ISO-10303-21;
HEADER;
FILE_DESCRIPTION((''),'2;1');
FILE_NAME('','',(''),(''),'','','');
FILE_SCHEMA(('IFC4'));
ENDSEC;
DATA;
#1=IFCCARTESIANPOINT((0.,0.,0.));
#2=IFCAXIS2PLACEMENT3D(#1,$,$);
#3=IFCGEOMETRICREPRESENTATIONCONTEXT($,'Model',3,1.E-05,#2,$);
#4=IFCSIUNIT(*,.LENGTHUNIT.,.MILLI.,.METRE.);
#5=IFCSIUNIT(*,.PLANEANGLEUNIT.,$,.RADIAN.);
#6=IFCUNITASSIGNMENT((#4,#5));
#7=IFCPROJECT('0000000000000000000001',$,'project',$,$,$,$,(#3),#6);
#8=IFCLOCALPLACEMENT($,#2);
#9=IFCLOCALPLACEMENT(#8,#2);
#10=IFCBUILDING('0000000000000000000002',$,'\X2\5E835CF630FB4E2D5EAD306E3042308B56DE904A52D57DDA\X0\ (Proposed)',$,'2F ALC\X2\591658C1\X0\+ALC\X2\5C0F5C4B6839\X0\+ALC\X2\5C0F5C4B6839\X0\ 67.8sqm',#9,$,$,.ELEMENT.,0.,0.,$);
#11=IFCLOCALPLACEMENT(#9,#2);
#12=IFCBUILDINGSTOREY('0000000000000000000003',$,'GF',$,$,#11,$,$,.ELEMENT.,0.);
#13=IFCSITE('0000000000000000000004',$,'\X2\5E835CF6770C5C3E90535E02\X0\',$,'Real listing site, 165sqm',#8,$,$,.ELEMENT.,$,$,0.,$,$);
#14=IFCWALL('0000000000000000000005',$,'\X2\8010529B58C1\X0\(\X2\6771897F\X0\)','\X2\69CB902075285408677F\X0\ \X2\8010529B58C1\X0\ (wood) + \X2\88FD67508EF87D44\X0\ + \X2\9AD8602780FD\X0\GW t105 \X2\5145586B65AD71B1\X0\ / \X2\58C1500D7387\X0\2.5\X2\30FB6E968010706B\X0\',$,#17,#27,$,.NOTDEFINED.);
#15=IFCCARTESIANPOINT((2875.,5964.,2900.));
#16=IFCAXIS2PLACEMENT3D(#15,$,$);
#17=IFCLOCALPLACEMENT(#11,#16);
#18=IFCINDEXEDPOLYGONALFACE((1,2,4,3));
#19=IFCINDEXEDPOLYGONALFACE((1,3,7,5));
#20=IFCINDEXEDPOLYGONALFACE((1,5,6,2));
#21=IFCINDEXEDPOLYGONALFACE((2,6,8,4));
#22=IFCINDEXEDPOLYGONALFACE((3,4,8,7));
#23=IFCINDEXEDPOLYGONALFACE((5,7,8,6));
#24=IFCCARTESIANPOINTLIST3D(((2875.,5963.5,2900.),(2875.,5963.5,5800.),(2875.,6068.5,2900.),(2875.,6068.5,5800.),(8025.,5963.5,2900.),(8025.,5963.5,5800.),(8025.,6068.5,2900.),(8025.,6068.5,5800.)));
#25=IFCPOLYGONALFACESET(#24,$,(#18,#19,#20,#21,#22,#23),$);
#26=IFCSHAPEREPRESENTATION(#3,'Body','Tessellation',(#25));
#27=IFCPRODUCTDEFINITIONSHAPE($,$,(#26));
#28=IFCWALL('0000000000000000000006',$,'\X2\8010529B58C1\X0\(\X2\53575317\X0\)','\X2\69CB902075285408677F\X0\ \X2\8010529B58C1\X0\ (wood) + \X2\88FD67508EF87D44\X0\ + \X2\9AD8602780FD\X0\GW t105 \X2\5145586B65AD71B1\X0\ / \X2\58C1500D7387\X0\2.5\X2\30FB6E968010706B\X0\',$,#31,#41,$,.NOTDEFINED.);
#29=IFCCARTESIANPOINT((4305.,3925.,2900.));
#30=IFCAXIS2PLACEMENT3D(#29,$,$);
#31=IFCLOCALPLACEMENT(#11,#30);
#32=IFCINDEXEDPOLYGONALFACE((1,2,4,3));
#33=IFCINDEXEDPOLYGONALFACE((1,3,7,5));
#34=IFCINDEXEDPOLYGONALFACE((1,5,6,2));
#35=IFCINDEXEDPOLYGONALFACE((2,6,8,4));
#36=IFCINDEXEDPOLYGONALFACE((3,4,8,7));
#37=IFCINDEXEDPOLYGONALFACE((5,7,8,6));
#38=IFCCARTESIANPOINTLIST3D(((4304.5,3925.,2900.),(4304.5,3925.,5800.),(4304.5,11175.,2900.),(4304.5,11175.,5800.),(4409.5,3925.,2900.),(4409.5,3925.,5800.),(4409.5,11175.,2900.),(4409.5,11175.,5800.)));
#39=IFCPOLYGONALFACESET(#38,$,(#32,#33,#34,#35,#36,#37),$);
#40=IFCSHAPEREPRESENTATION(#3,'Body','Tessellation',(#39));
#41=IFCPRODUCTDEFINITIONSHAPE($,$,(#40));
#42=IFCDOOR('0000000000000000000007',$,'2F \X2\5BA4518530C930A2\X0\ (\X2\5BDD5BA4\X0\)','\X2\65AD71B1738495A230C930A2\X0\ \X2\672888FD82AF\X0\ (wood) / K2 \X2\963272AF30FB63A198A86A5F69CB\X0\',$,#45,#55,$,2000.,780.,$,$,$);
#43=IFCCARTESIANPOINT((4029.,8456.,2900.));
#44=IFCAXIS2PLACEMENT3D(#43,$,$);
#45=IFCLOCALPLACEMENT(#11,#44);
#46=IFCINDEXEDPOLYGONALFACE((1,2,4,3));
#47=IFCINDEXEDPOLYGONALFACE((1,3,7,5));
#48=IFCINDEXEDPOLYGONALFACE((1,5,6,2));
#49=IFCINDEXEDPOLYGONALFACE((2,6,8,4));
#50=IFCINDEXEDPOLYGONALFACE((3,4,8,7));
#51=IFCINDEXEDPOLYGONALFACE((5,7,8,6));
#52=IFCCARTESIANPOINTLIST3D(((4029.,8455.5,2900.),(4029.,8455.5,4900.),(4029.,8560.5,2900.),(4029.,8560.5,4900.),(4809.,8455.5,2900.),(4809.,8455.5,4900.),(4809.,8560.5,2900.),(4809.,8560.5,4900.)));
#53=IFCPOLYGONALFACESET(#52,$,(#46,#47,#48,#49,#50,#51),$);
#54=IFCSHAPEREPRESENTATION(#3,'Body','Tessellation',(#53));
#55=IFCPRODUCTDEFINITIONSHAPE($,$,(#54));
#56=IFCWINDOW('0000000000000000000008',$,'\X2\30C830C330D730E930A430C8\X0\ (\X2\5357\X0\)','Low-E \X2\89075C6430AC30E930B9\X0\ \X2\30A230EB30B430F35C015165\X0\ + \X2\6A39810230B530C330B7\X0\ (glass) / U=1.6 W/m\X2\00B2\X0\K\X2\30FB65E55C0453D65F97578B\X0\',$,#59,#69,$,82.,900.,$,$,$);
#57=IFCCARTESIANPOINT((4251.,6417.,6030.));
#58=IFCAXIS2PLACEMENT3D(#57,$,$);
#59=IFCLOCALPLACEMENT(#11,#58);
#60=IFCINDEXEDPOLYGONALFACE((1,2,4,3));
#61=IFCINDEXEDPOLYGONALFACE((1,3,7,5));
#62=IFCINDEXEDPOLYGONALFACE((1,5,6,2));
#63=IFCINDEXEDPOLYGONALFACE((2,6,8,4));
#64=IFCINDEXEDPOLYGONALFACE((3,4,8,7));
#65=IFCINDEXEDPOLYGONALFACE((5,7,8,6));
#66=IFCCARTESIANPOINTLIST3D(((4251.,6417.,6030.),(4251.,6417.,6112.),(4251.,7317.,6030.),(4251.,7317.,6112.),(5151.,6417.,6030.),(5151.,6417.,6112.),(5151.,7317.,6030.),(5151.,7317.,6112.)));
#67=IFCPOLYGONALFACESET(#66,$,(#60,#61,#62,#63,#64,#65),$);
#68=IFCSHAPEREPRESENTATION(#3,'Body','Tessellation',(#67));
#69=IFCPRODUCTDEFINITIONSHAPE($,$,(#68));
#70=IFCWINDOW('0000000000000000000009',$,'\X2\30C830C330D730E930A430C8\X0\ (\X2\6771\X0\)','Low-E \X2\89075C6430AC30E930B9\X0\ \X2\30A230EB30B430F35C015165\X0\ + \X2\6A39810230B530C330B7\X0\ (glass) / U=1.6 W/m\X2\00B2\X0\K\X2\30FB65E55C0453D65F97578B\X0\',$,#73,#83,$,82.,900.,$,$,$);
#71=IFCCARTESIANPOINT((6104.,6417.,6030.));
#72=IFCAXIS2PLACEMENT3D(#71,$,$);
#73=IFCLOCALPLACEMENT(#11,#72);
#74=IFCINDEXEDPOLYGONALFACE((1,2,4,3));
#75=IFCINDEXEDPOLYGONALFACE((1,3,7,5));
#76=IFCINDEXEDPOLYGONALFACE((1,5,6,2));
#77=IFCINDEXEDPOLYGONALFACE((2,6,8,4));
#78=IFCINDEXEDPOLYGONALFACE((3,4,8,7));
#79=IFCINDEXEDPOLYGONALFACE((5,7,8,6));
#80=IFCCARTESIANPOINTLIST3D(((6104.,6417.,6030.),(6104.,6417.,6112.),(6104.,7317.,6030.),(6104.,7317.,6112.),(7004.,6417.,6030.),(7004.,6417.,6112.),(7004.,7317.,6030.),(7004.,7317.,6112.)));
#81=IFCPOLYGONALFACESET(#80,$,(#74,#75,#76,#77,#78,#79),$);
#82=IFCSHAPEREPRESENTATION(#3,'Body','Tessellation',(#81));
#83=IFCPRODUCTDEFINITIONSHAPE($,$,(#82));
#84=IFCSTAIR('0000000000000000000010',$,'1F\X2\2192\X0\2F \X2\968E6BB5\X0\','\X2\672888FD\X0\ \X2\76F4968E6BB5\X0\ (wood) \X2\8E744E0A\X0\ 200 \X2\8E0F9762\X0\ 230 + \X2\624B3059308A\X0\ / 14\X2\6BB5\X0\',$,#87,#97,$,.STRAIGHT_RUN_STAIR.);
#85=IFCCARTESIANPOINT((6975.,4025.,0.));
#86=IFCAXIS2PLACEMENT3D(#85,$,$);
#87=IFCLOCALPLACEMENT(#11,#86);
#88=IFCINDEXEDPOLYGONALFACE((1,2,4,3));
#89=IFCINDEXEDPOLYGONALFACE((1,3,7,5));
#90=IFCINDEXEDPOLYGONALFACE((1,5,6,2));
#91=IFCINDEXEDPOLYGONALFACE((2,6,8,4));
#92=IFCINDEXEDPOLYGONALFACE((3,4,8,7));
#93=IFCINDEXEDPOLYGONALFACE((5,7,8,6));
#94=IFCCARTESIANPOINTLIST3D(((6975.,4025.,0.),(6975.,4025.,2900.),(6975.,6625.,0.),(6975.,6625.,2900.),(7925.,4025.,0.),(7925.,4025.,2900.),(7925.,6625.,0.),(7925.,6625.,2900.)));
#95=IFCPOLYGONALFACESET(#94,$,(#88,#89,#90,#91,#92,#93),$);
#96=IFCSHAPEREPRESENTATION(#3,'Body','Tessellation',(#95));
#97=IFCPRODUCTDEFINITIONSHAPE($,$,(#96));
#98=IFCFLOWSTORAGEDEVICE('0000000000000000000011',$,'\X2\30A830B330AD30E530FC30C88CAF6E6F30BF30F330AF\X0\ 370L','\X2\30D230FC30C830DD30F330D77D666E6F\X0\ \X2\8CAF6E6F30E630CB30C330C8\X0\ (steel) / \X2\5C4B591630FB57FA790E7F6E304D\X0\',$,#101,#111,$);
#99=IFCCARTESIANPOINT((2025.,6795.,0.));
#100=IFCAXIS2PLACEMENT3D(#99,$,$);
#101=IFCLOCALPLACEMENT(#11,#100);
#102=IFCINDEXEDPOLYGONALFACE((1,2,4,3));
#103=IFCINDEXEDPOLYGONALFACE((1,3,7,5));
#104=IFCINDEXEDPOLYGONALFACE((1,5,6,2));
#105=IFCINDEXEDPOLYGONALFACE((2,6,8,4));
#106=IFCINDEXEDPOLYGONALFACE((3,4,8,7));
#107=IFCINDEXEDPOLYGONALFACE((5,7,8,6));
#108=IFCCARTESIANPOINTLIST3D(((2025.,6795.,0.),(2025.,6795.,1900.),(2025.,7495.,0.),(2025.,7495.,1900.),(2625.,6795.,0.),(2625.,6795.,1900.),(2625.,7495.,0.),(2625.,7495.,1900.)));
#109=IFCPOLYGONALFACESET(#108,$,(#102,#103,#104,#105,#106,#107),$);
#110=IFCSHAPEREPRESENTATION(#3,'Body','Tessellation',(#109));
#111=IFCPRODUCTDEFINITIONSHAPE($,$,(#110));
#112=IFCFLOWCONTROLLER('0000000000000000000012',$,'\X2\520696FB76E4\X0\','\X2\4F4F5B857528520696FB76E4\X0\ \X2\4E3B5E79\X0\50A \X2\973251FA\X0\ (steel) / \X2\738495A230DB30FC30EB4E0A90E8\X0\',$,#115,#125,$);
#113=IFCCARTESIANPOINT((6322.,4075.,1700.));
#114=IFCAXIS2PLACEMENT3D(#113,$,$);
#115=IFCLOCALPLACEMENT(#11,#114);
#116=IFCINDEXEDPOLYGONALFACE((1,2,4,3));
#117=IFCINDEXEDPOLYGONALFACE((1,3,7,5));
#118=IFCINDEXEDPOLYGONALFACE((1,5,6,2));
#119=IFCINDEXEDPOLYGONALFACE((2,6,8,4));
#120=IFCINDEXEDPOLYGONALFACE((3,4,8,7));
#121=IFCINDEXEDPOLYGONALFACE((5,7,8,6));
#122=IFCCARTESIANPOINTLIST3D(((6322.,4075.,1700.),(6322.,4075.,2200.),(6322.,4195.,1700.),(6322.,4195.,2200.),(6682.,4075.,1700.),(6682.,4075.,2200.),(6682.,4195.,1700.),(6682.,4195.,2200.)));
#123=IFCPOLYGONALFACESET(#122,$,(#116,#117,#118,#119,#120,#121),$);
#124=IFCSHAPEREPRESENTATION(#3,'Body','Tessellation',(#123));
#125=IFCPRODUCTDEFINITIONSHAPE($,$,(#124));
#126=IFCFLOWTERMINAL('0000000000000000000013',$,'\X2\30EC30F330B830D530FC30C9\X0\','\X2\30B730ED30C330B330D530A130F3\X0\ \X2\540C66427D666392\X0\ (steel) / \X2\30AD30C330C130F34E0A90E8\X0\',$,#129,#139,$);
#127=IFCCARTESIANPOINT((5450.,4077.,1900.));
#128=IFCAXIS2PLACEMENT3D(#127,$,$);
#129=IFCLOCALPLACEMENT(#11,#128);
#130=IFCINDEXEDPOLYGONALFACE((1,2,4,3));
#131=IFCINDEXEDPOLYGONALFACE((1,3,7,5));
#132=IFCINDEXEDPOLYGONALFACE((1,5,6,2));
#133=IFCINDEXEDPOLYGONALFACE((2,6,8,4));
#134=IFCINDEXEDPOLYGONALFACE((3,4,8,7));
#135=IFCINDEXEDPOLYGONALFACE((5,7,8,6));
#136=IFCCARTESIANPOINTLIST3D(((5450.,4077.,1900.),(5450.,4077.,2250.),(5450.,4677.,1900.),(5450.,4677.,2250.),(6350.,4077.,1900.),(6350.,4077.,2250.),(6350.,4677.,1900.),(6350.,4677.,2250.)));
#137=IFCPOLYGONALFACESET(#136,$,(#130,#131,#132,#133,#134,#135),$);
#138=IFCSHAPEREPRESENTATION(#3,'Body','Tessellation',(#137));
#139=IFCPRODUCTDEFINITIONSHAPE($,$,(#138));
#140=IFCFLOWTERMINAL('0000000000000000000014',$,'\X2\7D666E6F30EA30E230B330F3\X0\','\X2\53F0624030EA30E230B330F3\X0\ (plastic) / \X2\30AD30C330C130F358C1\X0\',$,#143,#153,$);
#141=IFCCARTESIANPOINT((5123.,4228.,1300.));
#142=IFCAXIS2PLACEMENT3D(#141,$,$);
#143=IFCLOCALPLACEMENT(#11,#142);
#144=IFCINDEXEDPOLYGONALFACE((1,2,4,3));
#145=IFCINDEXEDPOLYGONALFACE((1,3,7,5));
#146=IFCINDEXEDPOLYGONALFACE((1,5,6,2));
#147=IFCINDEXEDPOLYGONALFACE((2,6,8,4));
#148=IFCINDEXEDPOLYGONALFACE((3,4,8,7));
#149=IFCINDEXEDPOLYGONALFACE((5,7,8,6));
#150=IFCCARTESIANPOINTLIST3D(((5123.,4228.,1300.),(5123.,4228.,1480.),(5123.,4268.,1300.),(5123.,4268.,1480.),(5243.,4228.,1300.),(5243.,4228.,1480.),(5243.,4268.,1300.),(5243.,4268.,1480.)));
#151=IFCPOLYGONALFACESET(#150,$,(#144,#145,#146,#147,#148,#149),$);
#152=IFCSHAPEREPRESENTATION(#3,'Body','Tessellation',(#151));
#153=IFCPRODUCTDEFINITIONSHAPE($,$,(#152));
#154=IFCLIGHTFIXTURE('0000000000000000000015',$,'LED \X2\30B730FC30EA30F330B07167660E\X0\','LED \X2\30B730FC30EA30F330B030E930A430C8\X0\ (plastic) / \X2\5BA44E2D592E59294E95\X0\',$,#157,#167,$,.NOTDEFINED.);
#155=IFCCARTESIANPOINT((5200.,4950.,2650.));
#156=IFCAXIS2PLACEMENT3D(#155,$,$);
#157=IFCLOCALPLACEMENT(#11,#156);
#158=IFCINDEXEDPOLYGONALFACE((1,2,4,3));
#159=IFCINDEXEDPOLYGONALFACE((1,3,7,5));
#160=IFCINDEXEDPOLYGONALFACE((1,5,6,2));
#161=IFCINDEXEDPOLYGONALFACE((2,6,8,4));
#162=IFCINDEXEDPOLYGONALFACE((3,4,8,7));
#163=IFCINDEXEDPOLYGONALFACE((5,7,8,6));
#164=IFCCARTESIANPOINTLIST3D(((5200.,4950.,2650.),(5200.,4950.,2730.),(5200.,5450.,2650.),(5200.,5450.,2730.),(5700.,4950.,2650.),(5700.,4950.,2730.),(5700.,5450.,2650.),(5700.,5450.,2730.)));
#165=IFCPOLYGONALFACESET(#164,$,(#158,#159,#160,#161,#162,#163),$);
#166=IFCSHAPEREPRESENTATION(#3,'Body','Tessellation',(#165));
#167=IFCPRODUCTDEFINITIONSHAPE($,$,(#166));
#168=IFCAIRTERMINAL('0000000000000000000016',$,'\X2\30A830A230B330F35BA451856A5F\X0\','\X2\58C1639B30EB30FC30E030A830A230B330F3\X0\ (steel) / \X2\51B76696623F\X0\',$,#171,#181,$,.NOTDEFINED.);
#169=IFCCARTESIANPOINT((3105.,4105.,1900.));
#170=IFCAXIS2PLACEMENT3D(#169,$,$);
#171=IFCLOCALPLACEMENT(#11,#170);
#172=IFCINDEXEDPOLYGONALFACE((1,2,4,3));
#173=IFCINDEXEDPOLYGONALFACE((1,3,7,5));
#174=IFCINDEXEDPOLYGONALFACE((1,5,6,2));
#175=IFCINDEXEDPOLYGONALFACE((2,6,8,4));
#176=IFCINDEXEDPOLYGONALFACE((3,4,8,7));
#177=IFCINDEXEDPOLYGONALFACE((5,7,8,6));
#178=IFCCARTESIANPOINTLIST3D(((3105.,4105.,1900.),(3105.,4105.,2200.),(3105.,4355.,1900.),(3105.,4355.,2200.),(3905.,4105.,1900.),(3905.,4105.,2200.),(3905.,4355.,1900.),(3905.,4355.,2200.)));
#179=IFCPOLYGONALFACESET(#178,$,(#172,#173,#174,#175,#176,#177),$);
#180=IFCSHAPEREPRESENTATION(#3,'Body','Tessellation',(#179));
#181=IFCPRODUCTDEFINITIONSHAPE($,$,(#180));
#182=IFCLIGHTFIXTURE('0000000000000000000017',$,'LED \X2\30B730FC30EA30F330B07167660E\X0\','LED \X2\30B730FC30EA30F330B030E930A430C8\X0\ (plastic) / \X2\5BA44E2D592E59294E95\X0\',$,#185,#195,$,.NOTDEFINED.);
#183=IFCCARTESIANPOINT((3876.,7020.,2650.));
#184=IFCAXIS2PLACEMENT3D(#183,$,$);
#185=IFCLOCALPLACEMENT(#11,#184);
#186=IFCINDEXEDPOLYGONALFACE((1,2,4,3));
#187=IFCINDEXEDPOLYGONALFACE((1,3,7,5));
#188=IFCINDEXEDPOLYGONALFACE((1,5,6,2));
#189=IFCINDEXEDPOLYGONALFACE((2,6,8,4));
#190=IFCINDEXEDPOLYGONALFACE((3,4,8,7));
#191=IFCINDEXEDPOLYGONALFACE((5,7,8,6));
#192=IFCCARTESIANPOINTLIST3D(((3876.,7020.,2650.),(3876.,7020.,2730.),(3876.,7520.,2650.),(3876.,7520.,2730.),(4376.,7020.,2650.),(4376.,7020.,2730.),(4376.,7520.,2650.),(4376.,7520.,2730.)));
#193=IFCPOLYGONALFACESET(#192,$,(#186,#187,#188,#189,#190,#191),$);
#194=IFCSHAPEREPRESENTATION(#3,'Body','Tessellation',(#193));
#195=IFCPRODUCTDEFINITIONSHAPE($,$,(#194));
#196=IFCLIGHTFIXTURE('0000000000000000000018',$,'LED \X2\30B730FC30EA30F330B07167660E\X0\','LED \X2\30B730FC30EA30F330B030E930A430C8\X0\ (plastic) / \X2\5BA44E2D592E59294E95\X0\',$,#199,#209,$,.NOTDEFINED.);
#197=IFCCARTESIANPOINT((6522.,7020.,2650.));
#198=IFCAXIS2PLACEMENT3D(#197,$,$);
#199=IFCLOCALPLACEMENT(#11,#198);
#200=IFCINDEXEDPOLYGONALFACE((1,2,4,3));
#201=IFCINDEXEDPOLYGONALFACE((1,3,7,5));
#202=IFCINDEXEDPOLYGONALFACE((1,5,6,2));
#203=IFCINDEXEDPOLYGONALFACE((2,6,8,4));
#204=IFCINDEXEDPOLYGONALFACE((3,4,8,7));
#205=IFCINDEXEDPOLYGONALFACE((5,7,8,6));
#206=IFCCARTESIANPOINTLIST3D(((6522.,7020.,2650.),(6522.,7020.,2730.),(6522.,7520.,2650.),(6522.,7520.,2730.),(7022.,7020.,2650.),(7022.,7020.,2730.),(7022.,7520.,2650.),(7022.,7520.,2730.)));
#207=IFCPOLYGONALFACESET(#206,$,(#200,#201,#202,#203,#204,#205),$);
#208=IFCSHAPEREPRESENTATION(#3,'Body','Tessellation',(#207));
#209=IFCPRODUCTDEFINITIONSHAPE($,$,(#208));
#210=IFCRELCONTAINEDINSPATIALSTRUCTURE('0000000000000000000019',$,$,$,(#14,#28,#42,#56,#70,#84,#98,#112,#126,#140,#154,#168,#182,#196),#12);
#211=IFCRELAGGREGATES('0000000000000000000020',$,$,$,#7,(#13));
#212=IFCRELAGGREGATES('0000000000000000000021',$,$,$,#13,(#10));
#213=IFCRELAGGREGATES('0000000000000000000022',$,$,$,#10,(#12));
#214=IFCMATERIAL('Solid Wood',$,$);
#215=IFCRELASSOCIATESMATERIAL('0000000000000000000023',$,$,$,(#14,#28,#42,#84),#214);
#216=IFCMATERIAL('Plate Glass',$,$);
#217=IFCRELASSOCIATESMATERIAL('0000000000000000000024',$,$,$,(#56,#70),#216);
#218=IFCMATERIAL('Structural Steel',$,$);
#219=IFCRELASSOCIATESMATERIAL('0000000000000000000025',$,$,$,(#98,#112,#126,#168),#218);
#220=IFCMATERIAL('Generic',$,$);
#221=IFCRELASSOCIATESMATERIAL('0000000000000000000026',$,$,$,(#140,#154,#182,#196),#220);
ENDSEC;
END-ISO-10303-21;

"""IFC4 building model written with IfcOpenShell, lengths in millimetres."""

from ifc_helpers import new_model, si_unit, frame, frame_2d, origin, place, context, project, spatial, rectangle, extrude, material, element, fill, save


model = new_model("IFC4")

# Units and contexts
model_context = context("Model", 3, precision=1e-05, world=origin())
ifc_project = project(units=[si_unit("LENGTHUNIT", "METRE", prefix="MILLI"), si_unit("PLANEANGLEUNIT", "RADIAN")], contexts=[model_context])

# Site, building, storey
site_placement = place(None, origin())
site = spatial("IfcSite", under=ifc_project, at=site_placement, Name="広島県尾道市", ObjectType="Real listing site, 165sqm", CompositionType="ELEMENT", RefElevation=0.0)
building_placement = place(site_placement, origin())
building = spatial("IfcBuilding", under=site, at=building_placement, Name="広島・中庭のある回遊動線 (Proposed)", ObjectType="2F ALC外壁+ALC小屋根+ALC小屋根 67.8sqm", CompositionType="ELEMENT", ElevationOfRefHeight=0.0, ElevationOfTerrain=0.0)
storey_placement = place(building_placement, origin())
storey = spatial("IfcBuildingStorey", under=building, at=storey_placement, Name="GF", CompositionType="ELEMENT", Elevation=0.0)

# Shared definitions
ifc_material_1 = material(Name="Solid Wood")

# Wall
wall_1_placement = place(storey_placement, frame((2875.0, 5964.0, 2900.0)))
element("IfcWall", 1, at=wall_1_placement, inside=storey, material=ifc_material_1, Name="耐力壁(東西)", Description="構造用合板 耐力壁 (wood) + 製材軸組 + 高性能GW t105 充填断熱 / 壁倍率2.5・準耐火", PredefinedType="NOTDEFINED", context=model_context, shape_type="SweptSolid", body=[
    extrude(rectangle(XDim=5150.0, YDim=105.0, at=frame_2d((2575.0, 52.0))), frame((2875.0, 5964.0, 2900.0)), (0.0, 0.0, 1.0), 2900.0),
])

# Wall, opening, door
wall_2_placement = place(storey_placement, frame((4305.0, 3925.0, 2900.0)))
wall_2 = element("IfcWall", 2, at=wall_2_placement, inside=storey, material=ifc_material_1, Name="耐力壁(南北)", Description="構造用合板 耐力壁 (wood) + 製材軸組 + 高性能GW t105 充填断熱 / 壁倍率2.5・準耐火", PredefinedType="NOTDEFINED", context=model_context, shape_type="SweptSolid", body=[
    extrude(rectangle(XDim=105.0, YDim=7250.0, at=frame_2d((52.0, 3625.0))), frame((4305.0, 3925.0, 2900.0)), (0.0, 0.0, 1.0), 2900.0),
])
opening_placement = place(storey_placement, frame((4029.0, 8456.0, 2900.0)))
opening = element("IfcOpeningElement", 3, at=opening_placement, cuts=wall_2, PredefinedType="NOTDEFINED", context=model_context, shape_type="SweptSolid", body=[
    extrude(rectangle(XDim=780.0, YDim=105.0, at=frame_2d((390.0, 52.0))), frame((4029.0, 8456.0, 2900.0)), (0.0, 0.0, 1.0), 2000.0),
])
door_placement = place(storey_placement, frame((4029.0, 8456.0, 2900.0)))
door = element("IfcDoor", 4, at=door_placement, inside=storey, material=ifc_material_1, Name="2F 室内ドア (寝室)", Description="断熱玄関ドア 木製芯 (wood) / K2 防犯・採風機構", OverallHeight=2000.0, OverallWidth=780.0, context=model_context, shape_type="SweptSolid", body=[
    extrude(rectangle(XDim=780.0, YDim=105.0, at=frame_2d((390.0, 52.0))), frame((4029.0, 8456.0, 2900.0)), (0.0, 0.0, 1.0), 2000.0),
])
fill(opening, door)

# Windows
ifc_material_2 = material(Name="Plate Glass")
window_1_placement = place(storey_placement, frame((4251.0, 6417.0, 6030.0)))
element("IfcWindow", 5, at=window_1_placement, inside=storey, material=ifc_material_2, Name="トップライト (南)", Description="Low-E 複層ガラス アルゴン封入 + 樹脂サッシ (glass) / U=1.6 W/m²K・日射取得型", OverallHeight=82.0, OverallWidth=900.0, context=model_context, shape_type="SweptSolid", body=[
    extrude(rectangle(XDim=900.0, YDim=900.0, at=frame_2d((450.0, 450.0))), frame((4251.0, 6417.0, 6030.0)), (0.0, 0.0, 1.0), 82.0),
])
window_2_placement = place(storey_placement, frame((6104.0, 6417.0, 6030.0)))
element("IfcWindow", 6, at=window_2_placement, inside=storey, material=ifc_material_2, Name="トップライト (東)", Description="Low-E 複層ガラス アルゴン封入 + 樹脂サッシ (glass) / U=1.6 W/m²K・日射取得型", OverallHeight=82.0, OverallWidth=900.0, context=model_context, shape_type="SweptSolid", body=[
    extrude(rectangle(XDim=900.0, YDim=900.0, at=frame_2d((450.0, 450.0))), frame((6104.0, 6417.0, 6030.0)), (0.0, 0.0, 1.0), 82.0),
])

# Stair
stair_placement = place(storey_placement, frame((6975.0, 4025.0, 0.0)))
element("IfcStair", 7, at=stair_placement, inside=storey, material=ifc_material_1, Name="1F→2F 階段", Description="木製 直階段 (wood) 蹴上 200 踏面 230 + 手すり / 14段", PredefinedType="STRAIGHT_RUN_STAIR", context=model_context, shape_type="SweptSolid", body=[
    extrude(rectangle(XDim=950.0, YDim=2600.0, at=frame_2d((475.0, 1300.0))), frame((6975.0, 4025.0, 0.0)), (0.0, 0.0, 1.0), 2900.0),
])

# Flow storage device
ifc_material_3 = material(Name="Structural Steel")
flow_storage_device_placement = place(storey_placement, frame((2025.0, 6795.0, 0.0)))
element("IfcFlowStorageDevice", 8, at=flow_storage_device_placement, inside=storey, material=ifc_material_3, Name="エコキュート貯湯タンク 370L", Description="ヒートポンプ給湯 貯湯ユニット (steel) / 屋外・基礎置き", context=model_context, shape_type="SweptSolid", body=[
    extrude(rectangle(XDim=600.0, YDim=700.0, at=frame_2d((300.0, 350.0))), frame((2025.0, 6795.0, 0.0)), (0.0, 0.0, 1.0), 1900.0),
])

# Flow controller
flow_controller_placement = place(storey_placement, frame((6322.0, 4075.0, 1700.0)))
element("IfcFlowController", 9, at=flow_controller_placement, inside=storey, material=ifc_material_3, Name="分電盤", Description="住宅用分電盤 主幹50A 露出 (steel) / 玄関ホール上部", context=model_context, shape_type="SweptSolid", body=[
    extrude(rectangle(XDim=360.0, YDim=120.0, at=frame_2d((180.0, 60.0))), frame((6322.0, 4075.0, 1700.0)), (0.0, 0.0, 1.0), 500.0),
])

# Flow terminals
flow_terminal_1_placement = place(storey_placement, frame((5450.0, 4077.0, 1900.0)))
element("IfcFlowTerminal", 10, at=flow_terminal_1_placement, inside=storey, material=ifc_material_3, Name="レンジフード", Description="シロッコファン 同時給排 (steel) / キッチン上部", context=model_context, shape_type="SweptSolid", body=[
    extrude(rectangle(XDim=900.0, YDim=600.0, at=frame_2d((450.0, 300.0))), frame((5450.0, 4077.0, 1900.0)), (0.0, 0.0, 1.0), 350.0),
])
ifc_material_4 = material(Name="Generic")
flow_terminal_2_placement = place(storey_placement, frame((5123.0, 4228.0, 1300.0)))
element("IfcFlowTerminal", 11, at=flow_terminal_2_placement, inside=storey, material=ifc_material_4, Name="給湯リモコン", Description="台所リモコン (plastic) / キッチン壁", context=model_context, shape_type="SweptSolid", body=[
    extrude(rectangle(XDim=120.0, YDim=40.0, at=frame_2d((60.0, 20.0))), frame((5123.0, 4228.0, 1300.0)), (0.0, 0.0, 1.0), 180.0),
])

# Light fixture
light_fixture_1_placement = place(storey_placement, frame((5200.0, 4950.0, 2650.0)))
element("IfcLightFixture", 12, at=light_fixture_1_placement, inside=storey, material=ifc_material_4, Name="LED シーリング照明", Description="LED シーリングライト (plastic) / 室中央天井", PredefinedType="NOTDEFINED", context=model_context, shape_type="SweptSolid", body=[
    extrude(rectangle(XDim=500.0, YDim=500.0, at=frame_2d((250.0, 250.0))), frame((5200.0, 4950.0, 2650.0)), (0.0, 0.0, 1.0), 80.0),
])

# Air terminal
air_terminal_1_placement = place(storey_placement, frame((3105.0, 4105.0, 1900.0)))
element("IfcAirTerminal", 13, at=air_terminal_1_placement, inside=storey, material=ifc_material_3, Name="エアコン室内機", Description="壁掛ルームエアコン (steel) / 冷暖房", PredefinedType="NOTDEFINED", context=model_context, shape_type="SweptSolid", body=[
    extrude(rectangle(XDim=800.0, YDim=250.0, at=frame_2d((400.0, 125.0))), frame((3105.0, 4105.0, 1900.0)), (0.0, 0.0, 1.0), 300.0),
])

# Light fixtures
light_fixture_2_placement = place(storey_placement, frame((3876.0, 7020.0, 2650.0)))
element("IfcLightFixture", 14, at=light_fixture_2_placement, inside=storey, material=ifc_material_4, Name="LED シーリング照明", Description="LED シーリングライト (plastic) / 室中央天井", PredefinedType="NOTDEFINED", context=model_context, shape_type="SweptSolid", body=[
    extrude(rectangle(XDim=500.0, YDim=500.0, at=frame_2d((250.0, 250.0))), frame((3876.0, 7020.0, 2650.0)), (0.0, 0.0, 1.0), 80.0),
])
light_fixture_3_placement = place(storey_placement, frame((6522.0, 7020.0, 2650.0)))
element("IfcLightFixture", 15, at=light_fixture_3_placement, inside=storey, material=ifc_material_4, Name="LED シーリング照明", Description="LED シーリングライト (plastic) / 室中央天井", PredefinedType="NOTDEFINED", context=model_context, shape_type="SweptSolid", body=[
    extrude(rectangle(XDim=500.0, YDim=500.0, at=frame_2d((250.0, 250.0))), frame((6522.0, 7020.0, 2650.0)), (0.0, 0.0, 1.0), 80.0),
])

save(model, "model.ifc")
